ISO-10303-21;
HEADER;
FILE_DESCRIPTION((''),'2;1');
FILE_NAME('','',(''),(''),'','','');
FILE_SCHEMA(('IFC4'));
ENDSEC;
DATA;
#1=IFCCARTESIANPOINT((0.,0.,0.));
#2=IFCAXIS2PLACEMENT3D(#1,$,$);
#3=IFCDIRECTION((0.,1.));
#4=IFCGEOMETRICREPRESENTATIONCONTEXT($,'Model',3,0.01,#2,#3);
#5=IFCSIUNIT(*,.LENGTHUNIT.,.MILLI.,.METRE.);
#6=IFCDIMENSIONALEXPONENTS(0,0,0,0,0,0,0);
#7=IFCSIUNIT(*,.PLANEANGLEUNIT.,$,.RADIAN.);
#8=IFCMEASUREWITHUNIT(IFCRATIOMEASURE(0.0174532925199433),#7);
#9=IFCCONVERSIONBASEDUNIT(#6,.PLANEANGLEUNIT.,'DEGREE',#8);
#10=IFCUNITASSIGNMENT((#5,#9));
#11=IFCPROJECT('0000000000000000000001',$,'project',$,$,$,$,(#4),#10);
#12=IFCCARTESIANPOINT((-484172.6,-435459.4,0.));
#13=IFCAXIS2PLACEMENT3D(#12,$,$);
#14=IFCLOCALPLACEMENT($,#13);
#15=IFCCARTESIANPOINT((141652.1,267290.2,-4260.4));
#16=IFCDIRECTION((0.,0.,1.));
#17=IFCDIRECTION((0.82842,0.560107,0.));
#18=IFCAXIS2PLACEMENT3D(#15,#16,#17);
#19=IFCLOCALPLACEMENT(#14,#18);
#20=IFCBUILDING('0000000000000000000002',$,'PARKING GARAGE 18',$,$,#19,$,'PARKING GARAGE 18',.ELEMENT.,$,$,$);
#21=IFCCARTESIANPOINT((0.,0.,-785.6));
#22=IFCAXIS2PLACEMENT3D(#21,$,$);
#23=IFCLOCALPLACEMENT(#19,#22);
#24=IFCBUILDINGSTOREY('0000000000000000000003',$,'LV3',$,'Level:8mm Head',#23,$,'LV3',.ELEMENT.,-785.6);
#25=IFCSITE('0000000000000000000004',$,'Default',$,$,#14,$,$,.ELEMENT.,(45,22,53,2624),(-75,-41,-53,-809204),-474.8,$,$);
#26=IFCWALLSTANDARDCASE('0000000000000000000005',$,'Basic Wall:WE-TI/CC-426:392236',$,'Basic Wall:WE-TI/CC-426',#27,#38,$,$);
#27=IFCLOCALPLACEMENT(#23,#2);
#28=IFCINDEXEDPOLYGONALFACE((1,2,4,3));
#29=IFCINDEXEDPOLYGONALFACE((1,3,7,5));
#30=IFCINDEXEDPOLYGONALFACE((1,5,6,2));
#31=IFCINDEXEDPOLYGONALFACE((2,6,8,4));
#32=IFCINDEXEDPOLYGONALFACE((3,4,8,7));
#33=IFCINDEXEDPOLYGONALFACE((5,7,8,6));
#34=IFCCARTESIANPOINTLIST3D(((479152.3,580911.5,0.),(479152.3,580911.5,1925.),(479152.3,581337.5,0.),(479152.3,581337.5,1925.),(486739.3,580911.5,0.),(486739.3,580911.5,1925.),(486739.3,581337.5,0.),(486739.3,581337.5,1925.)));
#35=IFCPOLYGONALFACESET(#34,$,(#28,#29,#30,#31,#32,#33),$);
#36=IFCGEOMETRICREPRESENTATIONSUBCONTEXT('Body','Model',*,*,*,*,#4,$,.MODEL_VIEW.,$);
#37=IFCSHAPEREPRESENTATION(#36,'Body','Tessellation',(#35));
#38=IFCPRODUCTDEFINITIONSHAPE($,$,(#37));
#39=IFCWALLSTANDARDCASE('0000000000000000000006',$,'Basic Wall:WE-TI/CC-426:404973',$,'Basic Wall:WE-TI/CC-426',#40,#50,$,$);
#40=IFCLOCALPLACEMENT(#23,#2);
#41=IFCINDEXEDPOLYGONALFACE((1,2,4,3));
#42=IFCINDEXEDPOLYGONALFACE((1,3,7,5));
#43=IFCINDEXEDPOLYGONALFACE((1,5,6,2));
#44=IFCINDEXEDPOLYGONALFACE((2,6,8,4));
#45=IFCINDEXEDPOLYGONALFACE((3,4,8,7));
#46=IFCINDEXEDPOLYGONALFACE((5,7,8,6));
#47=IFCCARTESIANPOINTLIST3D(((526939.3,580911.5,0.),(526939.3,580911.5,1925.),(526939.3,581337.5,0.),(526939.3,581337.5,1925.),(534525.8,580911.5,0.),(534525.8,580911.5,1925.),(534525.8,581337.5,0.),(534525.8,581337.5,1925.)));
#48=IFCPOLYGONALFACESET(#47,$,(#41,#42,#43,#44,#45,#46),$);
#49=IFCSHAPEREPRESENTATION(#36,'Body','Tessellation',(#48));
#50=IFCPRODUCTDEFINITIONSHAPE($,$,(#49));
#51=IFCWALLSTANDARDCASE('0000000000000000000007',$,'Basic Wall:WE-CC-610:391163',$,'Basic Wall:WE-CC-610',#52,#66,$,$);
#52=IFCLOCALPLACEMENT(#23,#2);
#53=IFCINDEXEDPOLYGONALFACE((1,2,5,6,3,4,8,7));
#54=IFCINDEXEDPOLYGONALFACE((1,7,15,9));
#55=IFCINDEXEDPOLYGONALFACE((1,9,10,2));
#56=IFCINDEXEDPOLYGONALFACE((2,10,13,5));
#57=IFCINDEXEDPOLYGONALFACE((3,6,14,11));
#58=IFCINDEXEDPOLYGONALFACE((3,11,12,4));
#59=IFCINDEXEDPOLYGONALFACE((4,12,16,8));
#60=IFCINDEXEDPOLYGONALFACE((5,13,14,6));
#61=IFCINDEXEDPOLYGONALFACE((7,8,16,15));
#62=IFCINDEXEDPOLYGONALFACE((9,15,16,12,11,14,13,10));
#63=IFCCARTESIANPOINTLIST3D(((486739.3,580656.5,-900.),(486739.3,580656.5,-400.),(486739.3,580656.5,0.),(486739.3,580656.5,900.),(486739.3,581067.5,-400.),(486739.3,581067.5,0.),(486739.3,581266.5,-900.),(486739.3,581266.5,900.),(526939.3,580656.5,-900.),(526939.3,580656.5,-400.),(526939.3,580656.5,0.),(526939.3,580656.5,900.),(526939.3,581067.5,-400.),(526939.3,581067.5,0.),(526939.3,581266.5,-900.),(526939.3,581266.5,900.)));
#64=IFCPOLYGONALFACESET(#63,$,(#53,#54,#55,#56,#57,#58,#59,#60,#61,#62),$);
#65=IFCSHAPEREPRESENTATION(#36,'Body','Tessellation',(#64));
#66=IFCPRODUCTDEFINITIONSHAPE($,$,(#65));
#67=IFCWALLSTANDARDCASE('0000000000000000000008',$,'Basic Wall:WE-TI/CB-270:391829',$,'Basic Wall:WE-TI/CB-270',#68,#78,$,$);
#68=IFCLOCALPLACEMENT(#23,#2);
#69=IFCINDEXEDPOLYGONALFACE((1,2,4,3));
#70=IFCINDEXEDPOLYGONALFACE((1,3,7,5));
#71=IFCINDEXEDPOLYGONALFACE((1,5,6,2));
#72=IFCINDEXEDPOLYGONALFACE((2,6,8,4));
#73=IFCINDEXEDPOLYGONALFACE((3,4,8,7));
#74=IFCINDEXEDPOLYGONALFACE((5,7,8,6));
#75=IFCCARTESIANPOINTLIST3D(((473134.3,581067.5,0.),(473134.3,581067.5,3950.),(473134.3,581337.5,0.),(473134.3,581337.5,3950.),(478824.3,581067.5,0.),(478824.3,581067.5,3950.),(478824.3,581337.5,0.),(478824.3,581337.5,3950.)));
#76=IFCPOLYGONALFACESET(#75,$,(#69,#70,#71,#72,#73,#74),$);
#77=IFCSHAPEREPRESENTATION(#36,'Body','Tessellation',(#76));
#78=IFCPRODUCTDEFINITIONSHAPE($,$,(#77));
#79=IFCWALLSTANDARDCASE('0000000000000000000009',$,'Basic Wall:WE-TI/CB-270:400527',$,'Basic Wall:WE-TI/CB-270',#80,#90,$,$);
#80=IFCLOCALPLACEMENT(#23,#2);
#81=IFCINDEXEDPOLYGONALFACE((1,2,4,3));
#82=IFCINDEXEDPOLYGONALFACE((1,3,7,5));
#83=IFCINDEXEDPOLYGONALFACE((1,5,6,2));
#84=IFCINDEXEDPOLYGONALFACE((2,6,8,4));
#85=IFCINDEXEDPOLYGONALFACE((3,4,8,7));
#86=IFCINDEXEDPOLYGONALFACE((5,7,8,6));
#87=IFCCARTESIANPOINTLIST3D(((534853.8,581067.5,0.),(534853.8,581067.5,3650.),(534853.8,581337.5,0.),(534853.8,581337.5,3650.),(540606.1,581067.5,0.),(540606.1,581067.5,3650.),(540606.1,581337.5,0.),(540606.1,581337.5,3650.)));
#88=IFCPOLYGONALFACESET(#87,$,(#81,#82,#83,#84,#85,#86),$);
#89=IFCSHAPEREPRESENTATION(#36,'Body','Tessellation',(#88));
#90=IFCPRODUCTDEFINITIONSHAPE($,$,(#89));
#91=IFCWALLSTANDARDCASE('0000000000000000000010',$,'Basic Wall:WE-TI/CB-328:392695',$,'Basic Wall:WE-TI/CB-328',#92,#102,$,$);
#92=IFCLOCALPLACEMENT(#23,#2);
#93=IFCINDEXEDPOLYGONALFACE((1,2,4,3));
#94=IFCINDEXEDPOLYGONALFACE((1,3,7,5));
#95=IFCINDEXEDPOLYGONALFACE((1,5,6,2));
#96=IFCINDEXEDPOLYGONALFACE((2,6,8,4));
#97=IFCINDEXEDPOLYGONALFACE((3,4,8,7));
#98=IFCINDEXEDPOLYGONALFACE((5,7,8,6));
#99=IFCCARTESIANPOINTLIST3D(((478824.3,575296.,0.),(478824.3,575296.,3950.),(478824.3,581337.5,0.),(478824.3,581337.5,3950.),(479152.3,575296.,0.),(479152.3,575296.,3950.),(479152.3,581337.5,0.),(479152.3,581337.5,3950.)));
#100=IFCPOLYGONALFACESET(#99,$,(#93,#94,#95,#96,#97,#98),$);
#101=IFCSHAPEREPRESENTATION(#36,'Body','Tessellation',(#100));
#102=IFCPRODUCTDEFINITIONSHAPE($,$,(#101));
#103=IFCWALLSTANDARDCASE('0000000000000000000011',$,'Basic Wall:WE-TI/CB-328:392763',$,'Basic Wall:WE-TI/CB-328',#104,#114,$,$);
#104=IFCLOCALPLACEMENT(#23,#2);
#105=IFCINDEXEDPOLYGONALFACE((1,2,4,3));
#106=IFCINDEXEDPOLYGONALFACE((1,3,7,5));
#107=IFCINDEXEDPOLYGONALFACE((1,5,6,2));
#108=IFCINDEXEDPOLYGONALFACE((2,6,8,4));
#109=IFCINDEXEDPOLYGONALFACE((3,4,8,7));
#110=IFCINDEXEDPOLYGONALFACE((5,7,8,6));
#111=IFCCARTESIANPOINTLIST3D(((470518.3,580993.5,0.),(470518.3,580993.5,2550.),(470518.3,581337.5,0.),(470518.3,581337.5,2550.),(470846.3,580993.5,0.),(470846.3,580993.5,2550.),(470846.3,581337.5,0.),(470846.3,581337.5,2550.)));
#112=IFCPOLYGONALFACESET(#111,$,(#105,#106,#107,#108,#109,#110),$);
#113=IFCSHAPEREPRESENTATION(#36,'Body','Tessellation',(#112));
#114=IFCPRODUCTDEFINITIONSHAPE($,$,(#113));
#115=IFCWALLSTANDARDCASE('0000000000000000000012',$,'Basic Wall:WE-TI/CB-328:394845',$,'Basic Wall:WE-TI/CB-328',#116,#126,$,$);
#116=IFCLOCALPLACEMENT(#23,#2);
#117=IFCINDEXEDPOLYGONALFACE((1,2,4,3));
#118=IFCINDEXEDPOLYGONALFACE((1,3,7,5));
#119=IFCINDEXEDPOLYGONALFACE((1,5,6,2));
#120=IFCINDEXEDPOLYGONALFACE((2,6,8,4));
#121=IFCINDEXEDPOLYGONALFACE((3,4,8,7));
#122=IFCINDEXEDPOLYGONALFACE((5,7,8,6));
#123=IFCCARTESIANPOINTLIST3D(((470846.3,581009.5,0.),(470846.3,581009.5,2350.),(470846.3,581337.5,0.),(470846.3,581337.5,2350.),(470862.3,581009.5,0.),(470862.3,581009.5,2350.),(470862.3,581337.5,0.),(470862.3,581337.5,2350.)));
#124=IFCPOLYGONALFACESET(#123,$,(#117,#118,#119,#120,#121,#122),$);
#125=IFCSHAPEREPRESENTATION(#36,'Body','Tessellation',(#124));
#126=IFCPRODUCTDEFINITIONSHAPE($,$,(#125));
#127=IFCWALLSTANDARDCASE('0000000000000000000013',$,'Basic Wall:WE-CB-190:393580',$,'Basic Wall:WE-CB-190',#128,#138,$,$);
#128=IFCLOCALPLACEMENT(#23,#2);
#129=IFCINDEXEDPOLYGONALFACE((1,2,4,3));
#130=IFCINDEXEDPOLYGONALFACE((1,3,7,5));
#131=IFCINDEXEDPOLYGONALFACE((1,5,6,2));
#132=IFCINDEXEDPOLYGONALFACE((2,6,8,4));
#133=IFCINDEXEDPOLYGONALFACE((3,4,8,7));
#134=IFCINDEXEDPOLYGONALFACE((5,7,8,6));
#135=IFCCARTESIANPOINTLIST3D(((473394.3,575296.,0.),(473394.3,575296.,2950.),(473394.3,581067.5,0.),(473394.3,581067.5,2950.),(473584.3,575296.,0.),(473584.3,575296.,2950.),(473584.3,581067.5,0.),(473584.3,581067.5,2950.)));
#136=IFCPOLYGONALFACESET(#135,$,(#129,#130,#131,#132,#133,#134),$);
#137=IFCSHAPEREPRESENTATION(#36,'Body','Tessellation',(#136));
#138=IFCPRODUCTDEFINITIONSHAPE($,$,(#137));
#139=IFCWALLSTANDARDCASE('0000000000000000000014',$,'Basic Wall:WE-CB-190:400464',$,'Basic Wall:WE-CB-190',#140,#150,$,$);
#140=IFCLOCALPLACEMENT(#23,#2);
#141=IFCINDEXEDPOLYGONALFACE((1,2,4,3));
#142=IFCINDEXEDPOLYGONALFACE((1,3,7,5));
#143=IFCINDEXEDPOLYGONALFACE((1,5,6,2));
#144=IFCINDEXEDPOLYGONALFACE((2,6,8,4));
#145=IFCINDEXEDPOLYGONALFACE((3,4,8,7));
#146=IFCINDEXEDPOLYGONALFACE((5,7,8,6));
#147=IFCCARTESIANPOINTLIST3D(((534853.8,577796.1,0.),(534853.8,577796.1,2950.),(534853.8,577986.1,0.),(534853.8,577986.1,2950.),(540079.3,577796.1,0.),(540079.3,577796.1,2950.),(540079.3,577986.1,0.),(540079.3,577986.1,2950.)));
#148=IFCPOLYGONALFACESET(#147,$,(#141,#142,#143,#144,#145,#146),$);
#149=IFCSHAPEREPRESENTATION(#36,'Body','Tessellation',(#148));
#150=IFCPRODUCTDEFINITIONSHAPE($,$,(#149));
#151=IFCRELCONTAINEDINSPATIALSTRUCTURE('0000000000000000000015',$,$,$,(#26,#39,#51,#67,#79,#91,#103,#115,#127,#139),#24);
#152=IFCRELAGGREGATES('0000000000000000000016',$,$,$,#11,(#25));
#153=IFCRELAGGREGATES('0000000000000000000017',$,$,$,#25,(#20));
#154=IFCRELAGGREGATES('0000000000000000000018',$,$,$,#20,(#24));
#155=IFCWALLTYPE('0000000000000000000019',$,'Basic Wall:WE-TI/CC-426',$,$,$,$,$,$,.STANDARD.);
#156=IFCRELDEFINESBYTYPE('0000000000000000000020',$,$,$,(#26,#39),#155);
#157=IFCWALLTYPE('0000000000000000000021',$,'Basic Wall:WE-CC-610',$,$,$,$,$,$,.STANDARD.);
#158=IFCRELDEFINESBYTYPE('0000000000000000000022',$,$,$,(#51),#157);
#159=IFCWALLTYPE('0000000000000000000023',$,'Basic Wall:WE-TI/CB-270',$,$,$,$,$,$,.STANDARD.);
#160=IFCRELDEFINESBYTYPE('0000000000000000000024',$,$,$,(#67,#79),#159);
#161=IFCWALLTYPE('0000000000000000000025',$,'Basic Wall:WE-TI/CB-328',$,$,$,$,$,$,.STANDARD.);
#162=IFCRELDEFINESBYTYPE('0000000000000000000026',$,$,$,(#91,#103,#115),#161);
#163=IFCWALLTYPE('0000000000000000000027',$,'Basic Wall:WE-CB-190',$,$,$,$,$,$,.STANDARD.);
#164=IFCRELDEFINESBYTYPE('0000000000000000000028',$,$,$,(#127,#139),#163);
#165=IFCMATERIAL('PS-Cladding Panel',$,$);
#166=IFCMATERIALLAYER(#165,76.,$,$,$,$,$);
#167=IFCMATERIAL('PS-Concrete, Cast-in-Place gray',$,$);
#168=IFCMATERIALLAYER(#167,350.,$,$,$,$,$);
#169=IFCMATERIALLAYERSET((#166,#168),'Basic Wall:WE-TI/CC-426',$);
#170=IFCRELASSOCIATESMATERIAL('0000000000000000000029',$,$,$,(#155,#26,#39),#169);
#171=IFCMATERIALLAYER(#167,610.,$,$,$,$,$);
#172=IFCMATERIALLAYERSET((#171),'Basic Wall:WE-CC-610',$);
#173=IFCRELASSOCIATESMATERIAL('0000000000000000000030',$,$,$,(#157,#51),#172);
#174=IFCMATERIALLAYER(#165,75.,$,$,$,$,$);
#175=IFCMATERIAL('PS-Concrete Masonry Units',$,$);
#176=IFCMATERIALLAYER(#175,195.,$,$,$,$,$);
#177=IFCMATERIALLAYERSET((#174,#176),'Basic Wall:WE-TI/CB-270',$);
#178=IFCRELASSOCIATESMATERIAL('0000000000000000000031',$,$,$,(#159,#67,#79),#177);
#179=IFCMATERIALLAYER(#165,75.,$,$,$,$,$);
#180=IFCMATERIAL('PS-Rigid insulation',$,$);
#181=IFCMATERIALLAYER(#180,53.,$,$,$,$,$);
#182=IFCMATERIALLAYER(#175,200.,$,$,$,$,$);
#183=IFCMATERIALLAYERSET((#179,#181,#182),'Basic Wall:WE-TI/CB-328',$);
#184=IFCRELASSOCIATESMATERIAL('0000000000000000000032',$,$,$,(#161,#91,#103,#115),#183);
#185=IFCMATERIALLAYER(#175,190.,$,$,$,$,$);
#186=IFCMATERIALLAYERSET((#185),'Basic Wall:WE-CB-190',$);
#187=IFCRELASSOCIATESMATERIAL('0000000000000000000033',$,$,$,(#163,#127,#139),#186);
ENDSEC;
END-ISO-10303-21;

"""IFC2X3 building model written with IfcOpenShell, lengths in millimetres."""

from ifc_helpers import new_model, entity, si_unit, converted_unit, direction, frame, frame_2d, origin, place, context, subcontext, project, spatial, rectangle, extrude, material, layer, layer_set, layer_usage, type_object, element, save


model = new_model("IFC2X3")

# Units and contexts
model_context = context("Model", 3, precision=0.01, world=origin(), true_north=direction((0.0, 1.0)))
body_context = subcontext(model_context, "Body", "Model", "MODEL_VIEW")
ifc_project = project(units=[si_unit("LENGTHUNIT", "METRE", prefix="MILLI"), converted_unit("PLANEANGLEUNIT", "DEGREE", entity("IfcRatioMeasure", 0.0174532925199433), si_unit("PLANEANGLEUNIT", "RADIAN"), dimensions=[0, 0, 0, 0, 0, 0, 0])], contexts=[model_context])

# Site, building, storey
site_placement = place(None, frame((-484172.6, -435459.4, 0.0)))
site = spatial("IfcSite", under=ifc_project, at=site_placement, Name="Default", CompositionType="ELEMENT", RefLatitude=(45, 22, 53, 2624), RefLongitude=(-75, -41, -53, -809204), RefElevation=-474.8)
building_placement = place(site_placement, frame((141652.1, 267290.2, -4260.4), z_axis=(0.0, 0.0, 1.0), x_axis=(0.82842, 0.560107, 0.0)))
building = spatial("IfcBuilding", under=site, at=building_placement, Name="PARKING GARAGE 18", LongName="PARKING GARAGE 18", CompositionType="ELEMENT")
storey_placement = place(building_placement, frame((0.0, 0.0, -785.6)))
storey = spatial("IfcBuildingStorey", under=building, at=storey_placement, Name="LV3", ObjectType="Level:8mm Head", LongName="LV3", CompositionType="ELEMENT", Elevation=-785.6)

# Walls
ifc_material_1 = material(Name="PS-Cladding Panel")
ifc_layer_1 = layer(ifc_material_1, 76.0)
ifc_material_2 = material(Name="PS-Concrete, Cast-in-Place gray")
ifc_layer_2 = layer(ifc_material_2, 350.0)
ifc_layer_set_1 = layer_set([ifc_layer_1, ifc_layer_2], Name="Basic Wall:WE-TI/CC-426")
ifc_layer_usage_1 = layer_usage(ifc_layer_set_1, "AXIS2", "NEGATIVE", 213.0)
wall_type_1 = type_object("IfcWallType", Name="Basic Wall:WE-TI/CC-426", PredefinedType="STANDARD", material=ifc_layer_set_1)
wall_1_placement = place(storey_placement, frame((479152.3, 581124.5, 0.0)))
element("IfcWallStandardCase", 1, at=wall_1_placement, inside=storey, type_object=wall_type_1, material=ifc_layer_usage_1, Name="Basic Wall:WE-TI/CC-426:392236", ObjectType="Basic Wall:WE-TI/CC-426", context=body_context, shape_type="SweptSolid", body=[
    extrude(rectangle(XDim=7587.0, YDim=426.0, at=frame_2d((3793.5, 0.0), x_axis=(-1.0, 0.0))), origin(), (0.0, 0.0, 1.0), 1925.0),
])
ifc_layer_usage_2 = layer_usage(ifc_layer_set_1, "AXIS2", "NEGATIVE", 213.0)
wall_2_placement = place(storey_placement, frame((526939.3, 581124.5, 0.0)))
element("IfcWallStandardCase", 2, at=wall_2_placement, inside=storey, type_object=wall_type_1, material=ifc_layer_usage_2, Name="Basic Wall:WE-TI/CC-426:404973", ObjectType="Basic Wall:WE-TI/CC-426", context=body_context, shape_type="SweptSolid", body=[
    extrude(rectangle(XDim=7586.5, YDim=426.0, at=frame_2d((3793.3, 0.0), x_axis=(-1.0, 0.0))), origin(), (0.0, 0.0, 1.0), 1925.0),
])

# Wall, opening
ifc_layer_3 = layer(ifc_material_2, 610.0)
ifc_layer_set_2 = layer_set([ifc_layer_3], Name="Basic Wall:WE-CC-610")
ifc_layer_usage_3 = layer_usage(ifc_layer_set_2, "AXIS2", "NEGATIVE", 305.0)
wall_type_2 = type_object("IfcWallType", Name="Basic Wall:WE-CC-610", PredefinedType="STANDARD", material=ifc_layer_set_2)
wall_3_placement = place(storey_placement, frame((486739.3, 580961.5, -900.0)))
wall_3 = element("IfcWallStandardCase", 3, at=wall_3_placement, inside=storey, type_object=wall_type_2, material=ifc_layer_usage_3, Name="Basic Wall:WE-CC-610:391163", ObjectType="Basic Wall:WE-CC-610", context=body_context, shape_type="SweptSolid", body=[
    extrude(rectangle(XDim=40200.0, YDim=610.0, at=frame_2d((20100.0, 0.0), x_axis=(-1.0, 0.0))), origin(), (0.0, 0.0, 1.0), 1800.0),
])
opening_placement = place(storey_placement, frame((486739.3, 580961.5, -900.0)))
element("IfcOpeningElement", 4, at=opening_placement, cuts=wall_3, ObjectType="Opening", context=body_context, shape_type="SweptSolid", body=[
    extrude(rectangle(XDim=40200.0, YDim=411.0, at=frame_2d((-5557.1, 65.8), x_axis=(1.0, 0.0))), frame((14542.9, -33.7, 500.0), z_axis=(0.0, 0.0, 1.0), x_axis=(-1.0, 0.0, 0.0)), (0.0, 0.0, 1.0), 400.0),
])

# Walls
ifc_layer_4 = layer(ifc_material_1, 75.0)
ifc_material_3 = material(Name="PS-Concrete Masonry Units")
ifc_layer_5 = layer(ifc_material_3, 195.0)
ifc_layer_set_3 = layer_set([ifc_layer_4, ifc_layer_5], Name="Basic Wall:WE-TI/CB-270")
ifc_layer_usage_4 = layer_usage(ifc_layer_set_3, "AXIS2", "NEGATIVE", 135.0)
wall_type_3 = type_object("IfcWallType", Name="Basic Wall:WE-TI/CB-270", PredefinedType="STANDARD", material=ifc_layer_set_3)
wall_4_placement = place(storey_placement, frame((473134.3, 581202.5, 0.0)))
element("IfcWallStandardCase", 5, at=wall_4_placement, inside=storey, type_object=wall_type_3, material=ifc_layer_usage_4, Name="Basic Wall:WE-TI/CB-270:391829", ObjectType="Basic Wall:WE-TI/CB-270", context=body_context, shape_type="SweptSolid", body=[
    extrude(rectangle(XDim=5690.0, YDim=270.0, at=frame_2d((2845.0, 0.0), x_axis=(-1.0, 0.0))), origin(), (0.0, 0.0, 1.0), 3950.0),
])
ifc_layer_usage_5 = layer_usage(ifc_layer_set_3, "AXIS2", "NEGATIVE", 135.0)
wall_5_placement = place(storey_placement, frame((534853.8, 581202.5, 0.0)))
element("IfcWallStandardCase", 6, at=wall_5_placement, inside=storey, type_object=wall_type_3, material=ifc_layer_usage_5, Name="Basic Wall:WE-TI/CB-270:400527", ObjectType="Basic Wall:WE-TI/CB-270", context=body_context, shape_type="SweptSolid", body=[
    extrude(rectangle(XDim=5752.3, YDim=270.0, at=frame_2d((2876.2, 0.0), x_axis=(-1.0, 0.0))), origin(), (0.0, 0.0, 1.0), 3650.0),
])
ifc_layer_6 = layer(ifc_material_1, 75.0)
ifc_material_4 = material(Name="PS-Rigid insulation")
ifc_layer_7 = layer(ifc_material_4, 53.0)
ifc_layer_8 = layer(ifc_material_3, 200.0)
ifc_layer_set_4 = layer_set([ifc_layer_6, ifc_layer_7, ifc_layer_8], Name="Basic Wall:WE-TI/CB-328")
ifc_layer_usage_6 = layer_usage(ifc_layer_set_4, "AXIS2", "POSITIVE", -164.0)
wall_type_4 = type_object("IfcWallType", Name="Basic Wall:WE-TI/CB-328", PredefinedType="STANDARD", material=ifc_layer_set_4)
wall_6_placement = place(storey_placement, frame((478988.3, 575296.0, 0.0), z_axis=(0.0, 0.0, 1.0), x_axis=(0.0, 1.0, 0.0)))
element("IfcWallStandardCase", 7, at=wall_6_placement, inside=storey, type_object=wall_type_4, material=ifc_layer_usage_6, Name="Basic Wall:WE-TI/CB-328:392695", ObjectType="Basic Wall:WE-TI/CB-328", context=body_context, shape_type="SweptSolid", body=[
    extrude(rectangle(XDim=6041.5, YDim=328.0, at=frame_2d((3020.7, 0.0), x_axis=(-1.0, 0.0))), origin(), (0.0, 0.0, 1.0), 3950.0),
])
ifc_layer_usage_7 = layer_usage(ifc_layer_set_4, "AXIS2", "POSITIVE", -164.0)
wall_7_placement = place(storey_placement, frame((470682.3, 581337.5, 0.0), z_axis=(0.0, 0.0, 1.0), x_axis=(0.0, -1.0, 0.0)))
element("IfcWallStandardCase", 8, at=wall_7_placement, inside=storey, type_object=wall_type_4, material=ifc_layer_usage_7, Name="Basic Wall:WE-TI/CB-328:392763", ObjectType="Basic Wall:WE-TI/CB-328", context=body_context, shape_type="SweptSolid", body=[
    extrude(rectangle(XDim=344.0, YDim=328.0, at=frame_2d((172.0, 0.0), x_axis=(-1.0, 0.0))), origin(), (0.0, 0.0, 1.0), 2550.0),
])
ifc_layer_usage_8 = layer_usage(ifc_layer_set_4, "AXIS2", "POSITIVE", -164.0)
wall_8_placement = place(storey_placement, frame((470862.3, 581173.5, 0.0), z_axis=(0.0, 0.0, 1.0), x_axis=(-1.0, 0.0, 0.0)))
element("IfcWallStandardCase", 9, at=wall_8_placement, inside=storey, type_object=wall_type_4, material=ifc_layer_usage_8, Name="Basic Wall:WE-TI/CB-328:394845", ObjectType="Basic Wall:WE-TI/CB-328", context=body_context, shape_type="SweptSolid", body=[
    extrude(rectangle(XDim=16.0, YDim=328.0, at=frame_2d((8.0, 0.0), x_axis=(-1.0, 0.0))), origin(), (0.0, 0.0, 1.0), 2350.0),
])
ifc_layer_9 = layer(ifc_material_3, 190.0)
ifc_layer_set_5 = layer_set([ifc_layer_9], Name="Basic Wall:WE-CB-190")
ifc_layer_usage_9 = layer_usage(ifc_layer_set_5, "AXIS2", "NEGATIVE", 95.0)
wall_type_5 = type_object("IfcWallType", Name="Basic Wall:WE-CB-190", PredefinedType="STANDARD", material=ifc_layer_set_5)
wall_9_placement = place(storey_placement, frame((473489.3, 581067.5, 0.0), z_axis=(0.0, 0.0, 1.0), x_axis=(0.0, -1.0, 0.0)))
element("IfcWallStandardCase", 10, at=wall_9_placement, inside=storey, type_object=wall_type_5, material=ifc_layer_usage_9, Name="Basic Wall:WE-CB-190:393580", ObjectType="Basic Wall:WE-CB-190", context=body_context, shape_type="SweptSolid", body=[
    extrude(rectangle(XDim=5771.5, YDim=190.0, at=frame_2d((2885.7, 0.0), x_axis=(-1.0, 0.0))), origin(), (0.0, 0.0, 1.0), 2950.0),
])
ifc_layer_usage_10 = layer_usage(ifc_layer_set_5, "AXIS2", "NEGATIVE", 95.0)
wall_10_placement = place(storey_placement, frame((534853.8, 577891.1, 0.0)))
element("IfcWallStandardCase", 11, at=wall_10_placement, inside=storey, type_object=wall_type_5, material=ifc_layer_usage_10, Name="Basic Wall:WE-CB-190:400464", ObjectType="Basic Wall:WE-CB-190", context=body_context, shape_type="SweptSolid", body=[
    extrude(rectangle(XDim=5225.5, YDim=190.0, at=frame_2d((2612.7, 0.0), x_axis=(-1.0, 0.0))), origin(), (0.0, 0.0, 1.0), 2950.0),
])

save(model, "model.ifc")
